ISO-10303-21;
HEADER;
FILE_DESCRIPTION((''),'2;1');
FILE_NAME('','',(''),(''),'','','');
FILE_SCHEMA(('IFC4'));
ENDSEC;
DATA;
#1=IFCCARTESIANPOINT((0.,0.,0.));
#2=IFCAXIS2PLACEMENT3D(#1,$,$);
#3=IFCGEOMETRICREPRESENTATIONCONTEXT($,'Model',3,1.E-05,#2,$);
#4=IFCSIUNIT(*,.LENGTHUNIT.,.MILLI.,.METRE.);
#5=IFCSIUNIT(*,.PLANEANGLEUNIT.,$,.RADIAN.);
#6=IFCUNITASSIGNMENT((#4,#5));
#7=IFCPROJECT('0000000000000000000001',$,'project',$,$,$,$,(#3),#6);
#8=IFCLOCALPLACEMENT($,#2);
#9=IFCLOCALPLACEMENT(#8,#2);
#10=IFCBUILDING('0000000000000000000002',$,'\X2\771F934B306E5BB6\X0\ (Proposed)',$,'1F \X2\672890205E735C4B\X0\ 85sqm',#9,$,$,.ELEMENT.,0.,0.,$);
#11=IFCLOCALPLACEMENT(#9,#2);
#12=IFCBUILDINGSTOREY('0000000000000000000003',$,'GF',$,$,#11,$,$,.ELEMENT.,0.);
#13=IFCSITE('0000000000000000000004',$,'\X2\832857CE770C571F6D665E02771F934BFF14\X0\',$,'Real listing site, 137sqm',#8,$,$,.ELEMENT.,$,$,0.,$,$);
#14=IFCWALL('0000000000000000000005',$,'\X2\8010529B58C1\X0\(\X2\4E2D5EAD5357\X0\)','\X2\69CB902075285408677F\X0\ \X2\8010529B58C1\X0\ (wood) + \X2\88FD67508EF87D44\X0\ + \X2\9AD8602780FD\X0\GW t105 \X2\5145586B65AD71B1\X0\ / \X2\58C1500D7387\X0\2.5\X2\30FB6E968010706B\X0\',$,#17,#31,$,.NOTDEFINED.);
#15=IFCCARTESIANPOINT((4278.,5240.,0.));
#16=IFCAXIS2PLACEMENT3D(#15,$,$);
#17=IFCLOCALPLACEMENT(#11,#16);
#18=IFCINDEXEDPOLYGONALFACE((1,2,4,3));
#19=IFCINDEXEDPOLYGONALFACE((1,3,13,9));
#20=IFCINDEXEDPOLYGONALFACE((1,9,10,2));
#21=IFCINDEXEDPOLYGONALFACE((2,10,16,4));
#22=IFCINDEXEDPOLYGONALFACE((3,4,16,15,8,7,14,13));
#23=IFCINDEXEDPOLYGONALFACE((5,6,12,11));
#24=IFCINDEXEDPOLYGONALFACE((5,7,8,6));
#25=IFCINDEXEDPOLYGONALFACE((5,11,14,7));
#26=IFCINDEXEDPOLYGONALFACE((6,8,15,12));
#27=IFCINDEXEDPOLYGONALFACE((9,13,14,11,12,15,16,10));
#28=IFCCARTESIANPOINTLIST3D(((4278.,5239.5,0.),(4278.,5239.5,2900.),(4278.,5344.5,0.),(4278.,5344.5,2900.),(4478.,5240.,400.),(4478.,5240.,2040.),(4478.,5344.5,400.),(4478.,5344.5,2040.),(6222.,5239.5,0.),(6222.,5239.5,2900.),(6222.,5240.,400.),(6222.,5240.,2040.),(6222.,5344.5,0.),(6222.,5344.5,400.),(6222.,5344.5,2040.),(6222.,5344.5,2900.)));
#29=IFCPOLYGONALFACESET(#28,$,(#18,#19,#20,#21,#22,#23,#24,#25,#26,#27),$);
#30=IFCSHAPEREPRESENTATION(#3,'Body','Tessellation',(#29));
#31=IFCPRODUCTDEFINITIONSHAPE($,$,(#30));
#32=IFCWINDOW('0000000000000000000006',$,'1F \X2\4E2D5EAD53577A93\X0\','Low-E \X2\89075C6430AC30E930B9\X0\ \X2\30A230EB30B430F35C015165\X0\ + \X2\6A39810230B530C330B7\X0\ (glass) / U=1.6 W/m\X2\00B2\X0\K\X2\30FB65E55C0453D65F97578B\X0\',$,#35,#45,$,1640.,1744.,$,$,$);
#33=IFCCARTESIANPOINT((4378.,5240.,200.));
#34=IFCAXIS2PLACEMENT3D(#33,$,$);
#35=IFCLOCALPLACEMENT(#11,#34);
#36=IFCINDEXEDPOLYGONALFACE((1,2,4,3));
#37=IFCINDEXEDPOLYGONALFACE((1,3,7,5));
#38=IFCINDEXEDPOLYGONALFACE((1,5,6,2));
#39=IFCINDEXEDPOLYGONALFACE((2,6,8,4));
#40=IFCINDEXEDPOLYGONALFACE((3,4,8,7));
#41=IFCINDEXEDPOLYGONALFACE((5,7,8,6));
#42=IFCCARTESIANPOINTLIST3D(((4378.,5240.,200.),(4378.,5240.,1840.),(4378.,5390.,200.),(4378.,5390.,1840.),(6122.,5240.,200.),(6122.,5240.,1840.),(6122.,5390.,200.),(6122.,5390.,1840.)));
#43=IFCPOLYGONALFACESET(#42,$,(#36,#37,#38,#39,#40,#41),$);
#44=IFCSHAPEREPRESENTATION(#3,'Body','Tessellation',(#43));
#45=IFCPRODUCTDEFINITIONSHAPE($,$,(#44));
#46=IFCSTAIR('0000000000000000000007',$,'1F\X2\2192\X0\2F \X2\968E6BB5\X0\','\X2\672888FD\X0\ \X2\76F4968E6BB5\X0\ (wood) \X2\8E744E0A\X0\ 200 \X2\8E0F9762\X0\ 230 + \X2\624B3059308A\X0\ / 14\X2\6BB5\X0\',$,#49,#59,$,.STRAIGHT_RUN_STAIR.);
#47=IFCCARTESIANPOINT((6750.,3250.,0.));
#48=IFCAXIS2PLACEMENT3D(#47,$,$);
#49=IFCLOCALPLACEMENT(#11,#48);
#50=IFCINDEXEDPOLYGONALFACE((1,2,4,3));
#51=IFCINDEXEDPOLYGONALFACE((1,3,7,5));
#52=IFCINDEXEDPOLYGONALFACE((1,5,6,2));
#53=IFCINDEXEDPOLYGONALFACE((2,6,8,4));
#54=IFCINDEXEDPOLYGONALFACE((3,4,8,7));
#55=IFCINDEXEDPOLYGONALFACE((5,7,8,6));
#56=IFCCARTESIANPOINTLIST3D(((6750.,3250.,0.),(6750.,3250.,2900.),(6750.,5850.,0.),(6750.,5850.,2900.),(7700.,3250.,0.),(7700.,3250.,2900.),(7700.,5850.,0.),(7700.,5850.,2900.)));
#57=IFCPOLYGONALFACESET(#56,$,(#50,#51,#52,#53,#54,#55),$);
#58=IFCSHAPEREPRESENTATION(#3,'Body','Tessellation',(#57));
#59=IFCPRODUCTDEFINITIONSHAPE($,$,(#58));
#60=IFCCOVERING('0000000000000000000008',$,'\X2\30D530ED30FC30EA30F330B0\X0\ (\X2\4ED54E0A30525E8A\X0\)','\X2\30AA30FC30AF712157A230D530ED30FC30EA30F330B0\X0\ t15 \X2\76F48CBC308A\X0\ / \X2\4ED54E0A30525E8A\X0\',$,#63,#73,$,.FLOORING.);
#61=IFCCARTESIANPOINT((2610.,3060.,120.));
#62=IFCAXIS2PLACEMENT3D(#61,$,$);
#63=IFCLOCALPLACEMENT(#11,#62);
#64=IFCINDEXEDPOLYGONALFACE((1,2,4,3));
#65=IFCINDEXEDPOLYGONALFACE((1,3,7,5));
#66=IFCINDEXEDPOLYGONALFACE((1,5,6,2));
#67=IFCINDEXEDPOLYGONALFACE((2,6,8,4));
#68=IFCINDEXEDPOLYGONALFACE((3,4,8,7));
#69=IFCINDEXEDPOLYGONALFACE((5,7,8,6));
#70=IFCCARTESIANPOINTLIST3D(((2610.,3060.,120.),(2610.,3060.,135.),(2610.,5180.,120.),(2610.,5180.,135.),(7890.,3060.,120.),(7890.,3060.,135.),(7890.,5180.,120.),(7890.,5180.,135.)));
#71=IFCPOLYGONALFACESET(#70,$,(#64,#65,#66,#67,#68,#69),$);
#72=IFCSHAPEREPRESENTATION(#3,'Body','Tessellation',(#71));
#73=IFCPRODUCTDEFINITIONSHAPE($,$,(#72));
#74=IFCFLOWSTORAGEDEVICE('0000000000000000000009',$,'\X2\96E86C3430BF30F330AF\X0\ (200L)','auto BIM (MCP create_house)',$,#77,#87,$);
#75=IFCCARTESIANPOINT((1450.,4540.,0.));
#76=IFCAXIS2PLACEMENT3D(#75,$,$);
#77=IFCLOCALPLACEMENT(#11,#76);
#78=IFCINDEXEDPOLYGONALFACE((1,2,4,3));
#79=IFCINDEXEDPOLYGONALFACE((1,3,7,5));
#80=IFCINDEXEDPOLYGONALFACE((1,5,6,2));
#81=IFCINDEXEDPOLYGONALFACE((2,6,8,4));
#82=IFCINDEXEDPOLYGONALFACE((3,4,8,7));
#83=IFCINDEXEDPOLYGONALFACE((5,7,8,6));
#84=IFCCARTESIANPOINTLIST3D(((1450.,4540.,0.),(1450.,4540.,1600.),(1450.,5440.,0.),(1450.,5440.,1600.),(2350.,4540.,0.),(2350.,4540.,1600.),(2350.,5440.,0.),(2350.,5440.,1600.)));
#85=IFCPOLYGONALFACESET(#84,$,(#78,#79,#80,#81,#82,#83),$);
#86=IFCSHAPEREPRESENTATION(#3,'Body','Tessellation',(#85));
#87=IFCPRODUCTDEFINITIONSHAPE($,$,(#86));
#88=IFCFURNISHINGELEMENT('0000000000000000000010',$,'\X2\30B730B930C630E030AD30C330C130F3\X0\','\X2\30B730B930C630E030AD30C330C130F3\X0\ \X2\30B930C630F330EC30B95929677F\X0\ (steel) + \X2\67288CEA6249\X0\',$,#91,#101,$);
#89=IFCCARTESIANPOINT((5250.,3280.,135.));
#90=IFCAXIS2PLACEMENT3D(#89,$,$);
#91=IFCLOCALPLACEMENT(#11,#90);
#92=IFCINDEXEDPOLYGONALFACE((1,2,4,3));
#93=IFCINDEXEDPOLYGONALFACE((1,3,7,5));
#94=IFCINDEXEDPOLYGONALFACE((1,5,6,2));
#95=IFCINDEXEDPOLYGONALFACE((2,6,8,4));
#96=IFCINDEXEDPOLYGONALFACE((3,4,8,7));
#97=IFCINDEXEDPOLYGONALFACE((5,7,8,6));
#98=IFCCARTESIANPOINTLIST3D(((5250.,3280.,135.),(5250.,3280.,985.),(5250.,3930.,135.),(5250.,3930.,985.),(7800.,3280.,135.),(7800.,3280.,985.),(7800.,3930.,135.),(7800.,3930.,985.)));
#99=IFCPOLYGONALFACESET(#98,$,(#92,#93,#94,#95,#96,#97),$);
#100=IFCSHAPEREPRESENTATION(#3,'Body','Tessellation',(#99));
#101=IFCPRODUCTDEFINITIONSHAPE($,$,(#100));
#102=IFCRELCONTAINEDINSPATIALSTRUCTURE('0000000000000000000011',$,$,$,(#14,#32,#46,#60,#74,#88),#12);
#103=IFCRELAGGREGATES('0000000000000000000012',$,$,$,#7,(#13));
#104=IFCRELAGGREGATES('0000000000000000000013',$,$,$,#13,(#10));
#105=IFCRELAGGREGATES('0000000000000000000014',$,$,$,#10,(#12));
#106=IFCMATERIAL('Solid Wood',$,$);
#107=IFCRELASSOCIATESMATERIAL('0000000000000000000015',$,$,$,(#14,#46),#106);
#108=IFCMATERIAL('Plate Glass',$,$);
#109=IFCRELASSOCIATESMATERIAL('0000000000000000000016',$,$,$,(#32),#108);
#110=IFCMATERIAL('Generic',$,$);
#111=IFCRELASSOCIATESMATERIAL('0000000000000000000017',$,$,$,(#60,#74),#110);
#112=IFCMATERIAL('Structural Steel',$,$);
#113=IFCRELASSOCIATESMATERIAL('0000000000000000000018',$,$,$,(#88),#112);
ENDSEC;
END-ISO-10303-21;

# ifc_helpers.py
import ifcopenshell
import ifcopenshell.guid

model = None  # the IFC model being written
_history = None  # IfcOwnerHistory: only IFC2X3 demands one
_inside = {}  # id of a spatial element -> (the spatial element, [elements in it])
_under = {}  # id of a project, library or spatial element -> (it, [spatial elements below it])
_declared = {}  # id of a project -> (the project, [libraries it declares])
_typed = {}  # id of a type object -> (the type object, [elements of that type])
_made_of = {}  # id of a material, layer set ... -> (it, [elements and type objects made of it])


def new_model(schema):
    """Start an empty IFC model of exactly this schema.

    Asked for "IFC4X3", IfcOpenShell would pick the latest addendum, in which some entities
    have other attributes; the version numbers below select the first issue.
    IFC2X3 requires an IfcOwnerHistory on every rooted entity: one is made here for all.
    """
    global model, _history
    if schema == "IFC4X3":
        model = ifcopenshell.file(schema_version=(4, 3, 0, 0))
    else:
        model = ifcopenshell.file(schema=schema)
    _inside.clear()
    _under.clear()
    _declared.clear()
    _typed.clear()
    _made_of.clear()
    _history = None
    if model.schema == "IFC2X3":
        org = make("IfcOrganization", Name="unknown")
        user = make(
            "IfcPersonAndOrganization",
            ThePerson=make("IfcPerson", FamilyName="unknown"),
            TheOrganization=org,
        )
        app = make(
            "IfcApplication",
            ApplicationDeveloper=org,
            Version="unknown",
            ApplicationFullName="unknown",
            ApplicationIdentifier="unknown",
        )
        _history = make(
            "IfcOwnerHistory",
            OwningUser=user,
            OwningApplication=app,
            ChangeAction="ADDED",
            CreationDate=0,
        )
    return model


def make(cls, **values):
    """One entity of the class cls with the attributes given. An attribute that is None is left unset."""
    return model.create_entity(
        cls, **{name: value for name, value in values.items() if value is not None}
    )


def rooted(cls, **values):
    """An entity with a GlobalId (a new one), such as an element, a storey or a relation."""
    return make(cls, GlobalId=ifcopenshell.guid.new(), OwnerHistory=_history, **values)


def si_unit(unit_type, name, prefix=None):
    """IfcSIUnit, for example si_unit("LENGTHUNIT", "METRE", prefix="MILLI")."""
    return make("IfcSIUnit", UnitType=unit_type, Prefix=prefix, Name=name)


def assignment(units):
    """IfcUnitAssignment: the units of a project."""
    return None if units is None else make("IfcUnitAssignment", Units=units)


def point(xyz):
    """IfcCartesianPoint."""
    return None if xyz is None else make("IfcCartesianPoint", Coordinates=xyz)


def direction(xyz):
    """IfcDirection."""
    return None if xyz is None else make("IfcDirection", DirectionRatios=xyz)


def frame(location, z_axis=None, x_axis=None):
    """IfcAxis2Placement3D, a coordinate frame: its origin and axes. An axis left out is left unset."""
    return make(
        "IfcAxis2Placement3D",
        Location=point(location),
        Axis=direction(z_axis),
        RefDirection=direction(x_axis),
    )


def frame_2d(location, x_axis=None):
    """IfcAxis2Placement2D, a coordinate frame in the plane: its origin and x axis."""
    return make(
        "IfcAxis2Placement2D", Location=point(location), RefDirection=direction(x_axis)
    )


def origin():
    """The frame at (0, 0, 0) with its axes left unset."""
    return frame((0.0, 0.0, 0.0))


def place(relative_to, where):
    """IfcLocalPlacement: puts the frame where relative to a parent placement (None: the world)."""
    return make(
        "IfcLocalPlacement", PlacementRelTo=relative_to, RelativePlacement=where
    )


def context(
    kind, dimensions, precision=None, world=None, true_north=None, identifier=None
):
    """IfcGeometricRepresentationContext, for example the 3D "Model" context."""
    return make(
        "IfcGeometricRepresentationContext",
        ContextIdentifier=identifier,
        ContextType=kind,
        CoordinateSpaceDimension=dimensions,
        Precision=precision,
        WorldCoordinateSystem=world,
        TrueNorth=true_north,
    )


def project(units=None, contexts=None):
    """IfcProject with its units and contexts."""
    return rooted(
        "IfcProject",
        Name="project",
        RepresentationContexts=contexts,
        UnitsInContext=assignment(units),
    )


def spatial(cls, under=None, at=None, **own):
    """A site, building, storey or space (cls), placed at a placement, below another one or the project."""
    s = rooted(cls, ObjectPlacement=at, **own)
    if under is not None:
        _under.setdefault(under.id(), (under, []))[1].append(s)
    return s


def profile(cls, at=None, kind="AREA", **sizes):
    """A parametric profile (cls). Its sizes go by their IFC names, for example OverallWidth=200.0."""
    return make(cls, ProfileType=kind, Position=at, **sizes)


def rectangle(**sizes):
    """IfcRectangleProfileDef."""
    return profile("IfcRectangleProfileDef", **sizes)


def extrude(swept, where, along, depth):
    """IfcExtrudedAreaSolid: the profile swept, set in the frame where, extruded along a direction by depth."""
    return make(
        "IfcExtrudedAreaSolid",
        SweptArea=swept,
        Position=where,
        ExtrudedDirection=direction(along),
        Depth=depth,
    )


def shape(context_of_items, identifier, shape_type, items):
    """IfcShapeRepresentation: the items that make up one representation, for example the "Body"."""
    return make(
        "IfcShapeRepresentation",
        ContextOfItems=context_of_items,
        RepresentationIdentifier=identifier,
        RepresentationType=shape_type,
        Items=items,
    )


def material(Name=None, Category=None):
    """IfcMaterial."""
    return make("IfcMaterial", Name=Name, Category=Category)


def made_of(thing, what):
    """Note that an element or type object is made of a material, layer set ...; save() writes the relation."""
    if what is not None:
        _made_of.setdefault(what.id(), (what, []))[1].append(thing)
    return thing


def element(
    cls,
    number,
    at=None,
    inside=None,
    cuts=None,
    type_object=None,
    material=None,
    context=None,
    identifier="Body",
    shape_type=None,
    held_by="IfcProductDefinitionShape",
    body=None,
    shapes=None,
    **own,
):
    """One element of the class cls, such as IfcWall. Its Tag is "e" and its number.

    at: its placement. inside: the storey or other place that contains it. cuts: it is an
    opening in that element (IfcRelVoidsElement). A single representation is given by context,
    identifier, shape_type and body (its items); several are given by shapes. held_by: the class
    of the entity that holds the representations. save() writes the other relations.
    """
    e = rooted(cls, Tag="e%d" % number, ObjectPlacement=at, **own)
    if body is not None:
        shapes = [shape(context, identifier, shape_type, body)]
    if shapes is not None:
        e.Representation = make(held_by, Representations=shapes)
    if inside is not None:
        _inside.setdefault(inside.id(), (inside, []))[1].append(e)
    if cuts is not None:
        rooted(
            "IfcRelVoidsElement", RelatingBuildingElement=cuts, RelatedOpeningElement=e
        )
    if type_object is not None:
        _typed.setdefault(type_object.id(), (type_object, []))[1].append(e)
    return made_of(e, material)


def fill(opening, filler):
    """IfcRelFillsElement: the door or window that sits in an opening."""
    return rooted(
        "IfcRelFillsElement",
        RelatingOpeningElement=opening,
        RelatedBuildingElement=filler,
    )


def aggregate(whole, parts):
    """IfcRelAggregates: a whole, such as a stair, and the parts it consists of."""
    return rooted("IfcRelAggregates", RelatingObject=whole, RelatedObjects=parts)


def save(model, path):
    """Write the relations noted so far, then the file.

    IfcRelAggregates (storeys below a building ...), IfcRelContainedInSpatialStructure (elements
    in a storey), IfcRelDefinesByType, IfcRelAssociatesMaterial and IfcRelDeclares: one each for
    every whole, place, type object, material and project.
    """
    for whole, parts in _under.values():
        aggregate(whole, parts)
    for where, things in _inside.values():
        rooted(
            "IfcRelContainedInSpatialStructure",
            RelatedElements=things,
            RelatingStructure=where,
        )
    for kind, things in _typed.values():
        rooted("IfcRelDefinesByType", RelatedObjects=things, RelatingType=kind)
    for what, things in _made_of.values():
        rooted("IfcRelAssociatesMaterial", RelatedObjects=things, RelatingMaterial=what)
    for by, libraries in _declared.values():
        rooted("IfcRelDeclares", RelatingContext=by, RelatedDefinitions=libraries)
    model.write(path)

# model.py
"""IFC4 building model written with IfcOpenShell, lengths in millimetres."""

from ifc_helpers import new_model, si_unit, frame, frame_2d, origin, place, context, project, spatial, rectangle, extrude, material, element, fill, save


model = new_model("IFC4")

# Units and contexts
model_context = context("Model", 3, precision=1e-05, world=origin())
ifc_project = project(units=[si_unit("LENGTHUNIT", "METRE", prefix="MILLI"), si_unit("PLANEANGLEUNIT", "RADIAN")], contexts=[model_context])

# Site, building, storey
site_placement = place(None, origin())
site = spatial("IfcSite", under=ifc_project, at=site_placement, Name="茨城県土浦市真鍋４", ObjectType="Real listing site, 137sqm", CompositionType="ELEMENT", RefElevation=0.0)
building_placement = place(site_placement, origin())
building = spatial("IfcBuilding", under=site, at=building_placement, Name="真鍋の家 (Proposed)", ObjectType="1F 木造平屋 85sqm", CompositionType="ELEMENT", ElevationOfRefHeight=0.0, ElevationOfTerrain=0.0)
storey_placement = place(building_placement, origin())
storey = spatial("IfcBuildingStorey", under=building, at=storey_placement, Name="GF", CompositionType="ELEMENT", Elevation=0.0)

# Shared definitions
ifc_material_1 = material(Name="Solid Wood")
ifc_material_2 = material(Name="Generic")

# Shared definitions
ifc_material_3 = material(Name="Plate Glass")

# Wall, opening, window
wall_1_placement = place(storey_placement, frame((4278.0, 5240.0, 0.0)))
wall_1 = element("IfcWall", 1, at=wall_1_placement, inside=storey, material=ifc_material_1, Name="耐力壁(中庭南)", Description="構造用合板 耐力壁 (wood) + 製材軸組 + 高性能GW t105 充填断熱 / 壁倍率2.5・準耐火", PredefinedType="NOTDEFINED", context=model_context, shape_type="SweptSolid", body=[
    extrude(rectangle(XDim=1944.0, YDim=105.0, at=frame_2d((972.0, 52.0))), frame((4278.0, 5240.0, 0.0)), (0.0, 0.0, 1.0), 2900.0),
])
opening_1_placement = place(storey_placement, frame((4378.0, 5240.0, 200.0)))
opening_1 = element("IfcOpeningElement", 2, at=opening_1_placement, cuts=wall_1, PredefinedType="NOTDEFINED", context=model_context, shape_type="SweptSolid", body=[
    extrude(rectangle(XDim=1744.0, YDim=150.0, at=frame_2d((872.0, 75.0))), frame((4378.0, 5240.0, 200.0)), (0.0, 0.0, 1.0), 1640.0),
])
window_1_placement = place(storey_placement, frame((4378.0, 5240.0, 200.0)))
window_1 = element("IfcWindow", 3, at=window_1_placement, inside=storey, material=ifc_material_3, Name="1F 中庭南窓", Description="Low-E 複層ガラス アルゴン封入 + 樹脂サッシ (glass) / U=1.6 W/m²K・日射取得型", OverallHeight=1640.0, OverallWidth=1744.0, context=model_context, shape_type="SweptSolid", body=[
    extrude(rectangle(XDim=1744.0, YDim=150.0, at=frame_2d((872.0, 75.0))), frame((4378.0, 5240.0, 200.0)), (0.0, 0.0, 1.0), 1640.0),
])
fill(opening_1, window_1)

# Stair
stair_placement = place(storey_placement, frame((6750.0, 3250.0, 0.0)))
element("IfcStair", 4, at=stair_placement, inside=storey, material=ifc_material_1, Name="1F→2F 階段", Description="木製 直階段 (wood) 蹴上 200 踏面 230 + 手すり / 14段", PredefinedType="STRAIGHT_RUN_STAIR", context=model_context, shape_type="SweptSolid", body=[
    extrude(rectangle(XDim=950.0, YDim=2600.0, at=frame_2d((475.0, 1300.0))), frame((6750.0, 3250.0, 0.0)), (0.0, 0.0, 1.0), 2900.0),
])

# Covering
covering_placement = place(storey_placement, frame((2610.0, 3060.0, 120.0)))
element("IfcCovering", 5, at=covering_placement, inside=storey, material=ifc_material_2, Name="フローリング (仕上げ床)", Description="オーク無垢フローリング t15 直貼り / 仕上げ床", PredefinedType="FLOORING", context=model_context, shape_type="SweptSolid", body=[
    extrude(rectangle(XDim=5280.0, YDim=2120.0, at=frame_2d((2640.0, 1060.0))), frame((2610.0, 3060.0, 120.0)), (0.0, 0.0, 1.0), 15.0),
])

# Flow storage device
flow_storage_device_placement = place(storey_placement, frame((1450.0, 4540.0, 0.0)))
element("IfcFlowStorageDevice", 6, at=flow_storage_device_placement, inside=storey, material=ifc_material_2, Name="雨水タンク (200L)", Description="auto BIM (MCP create_house)", context=model_context, shape_type="SweptSolid", body=[
    extrude(rectangle(XDim=900.0, YDim=900.0, at=frame_2d((450.0, 450.0))), frame((1450.0, 4540.0, 0.0)), (0.0, 0.0, 1.0), 1600.0),
])

# Furnishing element
ifc_material_4 = material(Name="Structural Steel")
furnishing_placement = place(storey_placement, frame((5250.0, 3280.0, 135.0)))
element("IfcFurnishingElement", 7, at=furnishing_placement, inside=storey, material=ifc_material_4, Name="システムキッチン", Description="システムキッチン ステンレス天板 (steel) + 木質扉", context=model_context, shape_type="SweptSolid", body=[
    extrude(rectangle(XDim=2550.0, YDim=650.0, at=frame_2d((1275.0, 325.0))), frame((5250.0, 3280.0, 135.0)), (0.0, 0.0, 1.0), 850.0),
])

save(model, "model.ifc")
